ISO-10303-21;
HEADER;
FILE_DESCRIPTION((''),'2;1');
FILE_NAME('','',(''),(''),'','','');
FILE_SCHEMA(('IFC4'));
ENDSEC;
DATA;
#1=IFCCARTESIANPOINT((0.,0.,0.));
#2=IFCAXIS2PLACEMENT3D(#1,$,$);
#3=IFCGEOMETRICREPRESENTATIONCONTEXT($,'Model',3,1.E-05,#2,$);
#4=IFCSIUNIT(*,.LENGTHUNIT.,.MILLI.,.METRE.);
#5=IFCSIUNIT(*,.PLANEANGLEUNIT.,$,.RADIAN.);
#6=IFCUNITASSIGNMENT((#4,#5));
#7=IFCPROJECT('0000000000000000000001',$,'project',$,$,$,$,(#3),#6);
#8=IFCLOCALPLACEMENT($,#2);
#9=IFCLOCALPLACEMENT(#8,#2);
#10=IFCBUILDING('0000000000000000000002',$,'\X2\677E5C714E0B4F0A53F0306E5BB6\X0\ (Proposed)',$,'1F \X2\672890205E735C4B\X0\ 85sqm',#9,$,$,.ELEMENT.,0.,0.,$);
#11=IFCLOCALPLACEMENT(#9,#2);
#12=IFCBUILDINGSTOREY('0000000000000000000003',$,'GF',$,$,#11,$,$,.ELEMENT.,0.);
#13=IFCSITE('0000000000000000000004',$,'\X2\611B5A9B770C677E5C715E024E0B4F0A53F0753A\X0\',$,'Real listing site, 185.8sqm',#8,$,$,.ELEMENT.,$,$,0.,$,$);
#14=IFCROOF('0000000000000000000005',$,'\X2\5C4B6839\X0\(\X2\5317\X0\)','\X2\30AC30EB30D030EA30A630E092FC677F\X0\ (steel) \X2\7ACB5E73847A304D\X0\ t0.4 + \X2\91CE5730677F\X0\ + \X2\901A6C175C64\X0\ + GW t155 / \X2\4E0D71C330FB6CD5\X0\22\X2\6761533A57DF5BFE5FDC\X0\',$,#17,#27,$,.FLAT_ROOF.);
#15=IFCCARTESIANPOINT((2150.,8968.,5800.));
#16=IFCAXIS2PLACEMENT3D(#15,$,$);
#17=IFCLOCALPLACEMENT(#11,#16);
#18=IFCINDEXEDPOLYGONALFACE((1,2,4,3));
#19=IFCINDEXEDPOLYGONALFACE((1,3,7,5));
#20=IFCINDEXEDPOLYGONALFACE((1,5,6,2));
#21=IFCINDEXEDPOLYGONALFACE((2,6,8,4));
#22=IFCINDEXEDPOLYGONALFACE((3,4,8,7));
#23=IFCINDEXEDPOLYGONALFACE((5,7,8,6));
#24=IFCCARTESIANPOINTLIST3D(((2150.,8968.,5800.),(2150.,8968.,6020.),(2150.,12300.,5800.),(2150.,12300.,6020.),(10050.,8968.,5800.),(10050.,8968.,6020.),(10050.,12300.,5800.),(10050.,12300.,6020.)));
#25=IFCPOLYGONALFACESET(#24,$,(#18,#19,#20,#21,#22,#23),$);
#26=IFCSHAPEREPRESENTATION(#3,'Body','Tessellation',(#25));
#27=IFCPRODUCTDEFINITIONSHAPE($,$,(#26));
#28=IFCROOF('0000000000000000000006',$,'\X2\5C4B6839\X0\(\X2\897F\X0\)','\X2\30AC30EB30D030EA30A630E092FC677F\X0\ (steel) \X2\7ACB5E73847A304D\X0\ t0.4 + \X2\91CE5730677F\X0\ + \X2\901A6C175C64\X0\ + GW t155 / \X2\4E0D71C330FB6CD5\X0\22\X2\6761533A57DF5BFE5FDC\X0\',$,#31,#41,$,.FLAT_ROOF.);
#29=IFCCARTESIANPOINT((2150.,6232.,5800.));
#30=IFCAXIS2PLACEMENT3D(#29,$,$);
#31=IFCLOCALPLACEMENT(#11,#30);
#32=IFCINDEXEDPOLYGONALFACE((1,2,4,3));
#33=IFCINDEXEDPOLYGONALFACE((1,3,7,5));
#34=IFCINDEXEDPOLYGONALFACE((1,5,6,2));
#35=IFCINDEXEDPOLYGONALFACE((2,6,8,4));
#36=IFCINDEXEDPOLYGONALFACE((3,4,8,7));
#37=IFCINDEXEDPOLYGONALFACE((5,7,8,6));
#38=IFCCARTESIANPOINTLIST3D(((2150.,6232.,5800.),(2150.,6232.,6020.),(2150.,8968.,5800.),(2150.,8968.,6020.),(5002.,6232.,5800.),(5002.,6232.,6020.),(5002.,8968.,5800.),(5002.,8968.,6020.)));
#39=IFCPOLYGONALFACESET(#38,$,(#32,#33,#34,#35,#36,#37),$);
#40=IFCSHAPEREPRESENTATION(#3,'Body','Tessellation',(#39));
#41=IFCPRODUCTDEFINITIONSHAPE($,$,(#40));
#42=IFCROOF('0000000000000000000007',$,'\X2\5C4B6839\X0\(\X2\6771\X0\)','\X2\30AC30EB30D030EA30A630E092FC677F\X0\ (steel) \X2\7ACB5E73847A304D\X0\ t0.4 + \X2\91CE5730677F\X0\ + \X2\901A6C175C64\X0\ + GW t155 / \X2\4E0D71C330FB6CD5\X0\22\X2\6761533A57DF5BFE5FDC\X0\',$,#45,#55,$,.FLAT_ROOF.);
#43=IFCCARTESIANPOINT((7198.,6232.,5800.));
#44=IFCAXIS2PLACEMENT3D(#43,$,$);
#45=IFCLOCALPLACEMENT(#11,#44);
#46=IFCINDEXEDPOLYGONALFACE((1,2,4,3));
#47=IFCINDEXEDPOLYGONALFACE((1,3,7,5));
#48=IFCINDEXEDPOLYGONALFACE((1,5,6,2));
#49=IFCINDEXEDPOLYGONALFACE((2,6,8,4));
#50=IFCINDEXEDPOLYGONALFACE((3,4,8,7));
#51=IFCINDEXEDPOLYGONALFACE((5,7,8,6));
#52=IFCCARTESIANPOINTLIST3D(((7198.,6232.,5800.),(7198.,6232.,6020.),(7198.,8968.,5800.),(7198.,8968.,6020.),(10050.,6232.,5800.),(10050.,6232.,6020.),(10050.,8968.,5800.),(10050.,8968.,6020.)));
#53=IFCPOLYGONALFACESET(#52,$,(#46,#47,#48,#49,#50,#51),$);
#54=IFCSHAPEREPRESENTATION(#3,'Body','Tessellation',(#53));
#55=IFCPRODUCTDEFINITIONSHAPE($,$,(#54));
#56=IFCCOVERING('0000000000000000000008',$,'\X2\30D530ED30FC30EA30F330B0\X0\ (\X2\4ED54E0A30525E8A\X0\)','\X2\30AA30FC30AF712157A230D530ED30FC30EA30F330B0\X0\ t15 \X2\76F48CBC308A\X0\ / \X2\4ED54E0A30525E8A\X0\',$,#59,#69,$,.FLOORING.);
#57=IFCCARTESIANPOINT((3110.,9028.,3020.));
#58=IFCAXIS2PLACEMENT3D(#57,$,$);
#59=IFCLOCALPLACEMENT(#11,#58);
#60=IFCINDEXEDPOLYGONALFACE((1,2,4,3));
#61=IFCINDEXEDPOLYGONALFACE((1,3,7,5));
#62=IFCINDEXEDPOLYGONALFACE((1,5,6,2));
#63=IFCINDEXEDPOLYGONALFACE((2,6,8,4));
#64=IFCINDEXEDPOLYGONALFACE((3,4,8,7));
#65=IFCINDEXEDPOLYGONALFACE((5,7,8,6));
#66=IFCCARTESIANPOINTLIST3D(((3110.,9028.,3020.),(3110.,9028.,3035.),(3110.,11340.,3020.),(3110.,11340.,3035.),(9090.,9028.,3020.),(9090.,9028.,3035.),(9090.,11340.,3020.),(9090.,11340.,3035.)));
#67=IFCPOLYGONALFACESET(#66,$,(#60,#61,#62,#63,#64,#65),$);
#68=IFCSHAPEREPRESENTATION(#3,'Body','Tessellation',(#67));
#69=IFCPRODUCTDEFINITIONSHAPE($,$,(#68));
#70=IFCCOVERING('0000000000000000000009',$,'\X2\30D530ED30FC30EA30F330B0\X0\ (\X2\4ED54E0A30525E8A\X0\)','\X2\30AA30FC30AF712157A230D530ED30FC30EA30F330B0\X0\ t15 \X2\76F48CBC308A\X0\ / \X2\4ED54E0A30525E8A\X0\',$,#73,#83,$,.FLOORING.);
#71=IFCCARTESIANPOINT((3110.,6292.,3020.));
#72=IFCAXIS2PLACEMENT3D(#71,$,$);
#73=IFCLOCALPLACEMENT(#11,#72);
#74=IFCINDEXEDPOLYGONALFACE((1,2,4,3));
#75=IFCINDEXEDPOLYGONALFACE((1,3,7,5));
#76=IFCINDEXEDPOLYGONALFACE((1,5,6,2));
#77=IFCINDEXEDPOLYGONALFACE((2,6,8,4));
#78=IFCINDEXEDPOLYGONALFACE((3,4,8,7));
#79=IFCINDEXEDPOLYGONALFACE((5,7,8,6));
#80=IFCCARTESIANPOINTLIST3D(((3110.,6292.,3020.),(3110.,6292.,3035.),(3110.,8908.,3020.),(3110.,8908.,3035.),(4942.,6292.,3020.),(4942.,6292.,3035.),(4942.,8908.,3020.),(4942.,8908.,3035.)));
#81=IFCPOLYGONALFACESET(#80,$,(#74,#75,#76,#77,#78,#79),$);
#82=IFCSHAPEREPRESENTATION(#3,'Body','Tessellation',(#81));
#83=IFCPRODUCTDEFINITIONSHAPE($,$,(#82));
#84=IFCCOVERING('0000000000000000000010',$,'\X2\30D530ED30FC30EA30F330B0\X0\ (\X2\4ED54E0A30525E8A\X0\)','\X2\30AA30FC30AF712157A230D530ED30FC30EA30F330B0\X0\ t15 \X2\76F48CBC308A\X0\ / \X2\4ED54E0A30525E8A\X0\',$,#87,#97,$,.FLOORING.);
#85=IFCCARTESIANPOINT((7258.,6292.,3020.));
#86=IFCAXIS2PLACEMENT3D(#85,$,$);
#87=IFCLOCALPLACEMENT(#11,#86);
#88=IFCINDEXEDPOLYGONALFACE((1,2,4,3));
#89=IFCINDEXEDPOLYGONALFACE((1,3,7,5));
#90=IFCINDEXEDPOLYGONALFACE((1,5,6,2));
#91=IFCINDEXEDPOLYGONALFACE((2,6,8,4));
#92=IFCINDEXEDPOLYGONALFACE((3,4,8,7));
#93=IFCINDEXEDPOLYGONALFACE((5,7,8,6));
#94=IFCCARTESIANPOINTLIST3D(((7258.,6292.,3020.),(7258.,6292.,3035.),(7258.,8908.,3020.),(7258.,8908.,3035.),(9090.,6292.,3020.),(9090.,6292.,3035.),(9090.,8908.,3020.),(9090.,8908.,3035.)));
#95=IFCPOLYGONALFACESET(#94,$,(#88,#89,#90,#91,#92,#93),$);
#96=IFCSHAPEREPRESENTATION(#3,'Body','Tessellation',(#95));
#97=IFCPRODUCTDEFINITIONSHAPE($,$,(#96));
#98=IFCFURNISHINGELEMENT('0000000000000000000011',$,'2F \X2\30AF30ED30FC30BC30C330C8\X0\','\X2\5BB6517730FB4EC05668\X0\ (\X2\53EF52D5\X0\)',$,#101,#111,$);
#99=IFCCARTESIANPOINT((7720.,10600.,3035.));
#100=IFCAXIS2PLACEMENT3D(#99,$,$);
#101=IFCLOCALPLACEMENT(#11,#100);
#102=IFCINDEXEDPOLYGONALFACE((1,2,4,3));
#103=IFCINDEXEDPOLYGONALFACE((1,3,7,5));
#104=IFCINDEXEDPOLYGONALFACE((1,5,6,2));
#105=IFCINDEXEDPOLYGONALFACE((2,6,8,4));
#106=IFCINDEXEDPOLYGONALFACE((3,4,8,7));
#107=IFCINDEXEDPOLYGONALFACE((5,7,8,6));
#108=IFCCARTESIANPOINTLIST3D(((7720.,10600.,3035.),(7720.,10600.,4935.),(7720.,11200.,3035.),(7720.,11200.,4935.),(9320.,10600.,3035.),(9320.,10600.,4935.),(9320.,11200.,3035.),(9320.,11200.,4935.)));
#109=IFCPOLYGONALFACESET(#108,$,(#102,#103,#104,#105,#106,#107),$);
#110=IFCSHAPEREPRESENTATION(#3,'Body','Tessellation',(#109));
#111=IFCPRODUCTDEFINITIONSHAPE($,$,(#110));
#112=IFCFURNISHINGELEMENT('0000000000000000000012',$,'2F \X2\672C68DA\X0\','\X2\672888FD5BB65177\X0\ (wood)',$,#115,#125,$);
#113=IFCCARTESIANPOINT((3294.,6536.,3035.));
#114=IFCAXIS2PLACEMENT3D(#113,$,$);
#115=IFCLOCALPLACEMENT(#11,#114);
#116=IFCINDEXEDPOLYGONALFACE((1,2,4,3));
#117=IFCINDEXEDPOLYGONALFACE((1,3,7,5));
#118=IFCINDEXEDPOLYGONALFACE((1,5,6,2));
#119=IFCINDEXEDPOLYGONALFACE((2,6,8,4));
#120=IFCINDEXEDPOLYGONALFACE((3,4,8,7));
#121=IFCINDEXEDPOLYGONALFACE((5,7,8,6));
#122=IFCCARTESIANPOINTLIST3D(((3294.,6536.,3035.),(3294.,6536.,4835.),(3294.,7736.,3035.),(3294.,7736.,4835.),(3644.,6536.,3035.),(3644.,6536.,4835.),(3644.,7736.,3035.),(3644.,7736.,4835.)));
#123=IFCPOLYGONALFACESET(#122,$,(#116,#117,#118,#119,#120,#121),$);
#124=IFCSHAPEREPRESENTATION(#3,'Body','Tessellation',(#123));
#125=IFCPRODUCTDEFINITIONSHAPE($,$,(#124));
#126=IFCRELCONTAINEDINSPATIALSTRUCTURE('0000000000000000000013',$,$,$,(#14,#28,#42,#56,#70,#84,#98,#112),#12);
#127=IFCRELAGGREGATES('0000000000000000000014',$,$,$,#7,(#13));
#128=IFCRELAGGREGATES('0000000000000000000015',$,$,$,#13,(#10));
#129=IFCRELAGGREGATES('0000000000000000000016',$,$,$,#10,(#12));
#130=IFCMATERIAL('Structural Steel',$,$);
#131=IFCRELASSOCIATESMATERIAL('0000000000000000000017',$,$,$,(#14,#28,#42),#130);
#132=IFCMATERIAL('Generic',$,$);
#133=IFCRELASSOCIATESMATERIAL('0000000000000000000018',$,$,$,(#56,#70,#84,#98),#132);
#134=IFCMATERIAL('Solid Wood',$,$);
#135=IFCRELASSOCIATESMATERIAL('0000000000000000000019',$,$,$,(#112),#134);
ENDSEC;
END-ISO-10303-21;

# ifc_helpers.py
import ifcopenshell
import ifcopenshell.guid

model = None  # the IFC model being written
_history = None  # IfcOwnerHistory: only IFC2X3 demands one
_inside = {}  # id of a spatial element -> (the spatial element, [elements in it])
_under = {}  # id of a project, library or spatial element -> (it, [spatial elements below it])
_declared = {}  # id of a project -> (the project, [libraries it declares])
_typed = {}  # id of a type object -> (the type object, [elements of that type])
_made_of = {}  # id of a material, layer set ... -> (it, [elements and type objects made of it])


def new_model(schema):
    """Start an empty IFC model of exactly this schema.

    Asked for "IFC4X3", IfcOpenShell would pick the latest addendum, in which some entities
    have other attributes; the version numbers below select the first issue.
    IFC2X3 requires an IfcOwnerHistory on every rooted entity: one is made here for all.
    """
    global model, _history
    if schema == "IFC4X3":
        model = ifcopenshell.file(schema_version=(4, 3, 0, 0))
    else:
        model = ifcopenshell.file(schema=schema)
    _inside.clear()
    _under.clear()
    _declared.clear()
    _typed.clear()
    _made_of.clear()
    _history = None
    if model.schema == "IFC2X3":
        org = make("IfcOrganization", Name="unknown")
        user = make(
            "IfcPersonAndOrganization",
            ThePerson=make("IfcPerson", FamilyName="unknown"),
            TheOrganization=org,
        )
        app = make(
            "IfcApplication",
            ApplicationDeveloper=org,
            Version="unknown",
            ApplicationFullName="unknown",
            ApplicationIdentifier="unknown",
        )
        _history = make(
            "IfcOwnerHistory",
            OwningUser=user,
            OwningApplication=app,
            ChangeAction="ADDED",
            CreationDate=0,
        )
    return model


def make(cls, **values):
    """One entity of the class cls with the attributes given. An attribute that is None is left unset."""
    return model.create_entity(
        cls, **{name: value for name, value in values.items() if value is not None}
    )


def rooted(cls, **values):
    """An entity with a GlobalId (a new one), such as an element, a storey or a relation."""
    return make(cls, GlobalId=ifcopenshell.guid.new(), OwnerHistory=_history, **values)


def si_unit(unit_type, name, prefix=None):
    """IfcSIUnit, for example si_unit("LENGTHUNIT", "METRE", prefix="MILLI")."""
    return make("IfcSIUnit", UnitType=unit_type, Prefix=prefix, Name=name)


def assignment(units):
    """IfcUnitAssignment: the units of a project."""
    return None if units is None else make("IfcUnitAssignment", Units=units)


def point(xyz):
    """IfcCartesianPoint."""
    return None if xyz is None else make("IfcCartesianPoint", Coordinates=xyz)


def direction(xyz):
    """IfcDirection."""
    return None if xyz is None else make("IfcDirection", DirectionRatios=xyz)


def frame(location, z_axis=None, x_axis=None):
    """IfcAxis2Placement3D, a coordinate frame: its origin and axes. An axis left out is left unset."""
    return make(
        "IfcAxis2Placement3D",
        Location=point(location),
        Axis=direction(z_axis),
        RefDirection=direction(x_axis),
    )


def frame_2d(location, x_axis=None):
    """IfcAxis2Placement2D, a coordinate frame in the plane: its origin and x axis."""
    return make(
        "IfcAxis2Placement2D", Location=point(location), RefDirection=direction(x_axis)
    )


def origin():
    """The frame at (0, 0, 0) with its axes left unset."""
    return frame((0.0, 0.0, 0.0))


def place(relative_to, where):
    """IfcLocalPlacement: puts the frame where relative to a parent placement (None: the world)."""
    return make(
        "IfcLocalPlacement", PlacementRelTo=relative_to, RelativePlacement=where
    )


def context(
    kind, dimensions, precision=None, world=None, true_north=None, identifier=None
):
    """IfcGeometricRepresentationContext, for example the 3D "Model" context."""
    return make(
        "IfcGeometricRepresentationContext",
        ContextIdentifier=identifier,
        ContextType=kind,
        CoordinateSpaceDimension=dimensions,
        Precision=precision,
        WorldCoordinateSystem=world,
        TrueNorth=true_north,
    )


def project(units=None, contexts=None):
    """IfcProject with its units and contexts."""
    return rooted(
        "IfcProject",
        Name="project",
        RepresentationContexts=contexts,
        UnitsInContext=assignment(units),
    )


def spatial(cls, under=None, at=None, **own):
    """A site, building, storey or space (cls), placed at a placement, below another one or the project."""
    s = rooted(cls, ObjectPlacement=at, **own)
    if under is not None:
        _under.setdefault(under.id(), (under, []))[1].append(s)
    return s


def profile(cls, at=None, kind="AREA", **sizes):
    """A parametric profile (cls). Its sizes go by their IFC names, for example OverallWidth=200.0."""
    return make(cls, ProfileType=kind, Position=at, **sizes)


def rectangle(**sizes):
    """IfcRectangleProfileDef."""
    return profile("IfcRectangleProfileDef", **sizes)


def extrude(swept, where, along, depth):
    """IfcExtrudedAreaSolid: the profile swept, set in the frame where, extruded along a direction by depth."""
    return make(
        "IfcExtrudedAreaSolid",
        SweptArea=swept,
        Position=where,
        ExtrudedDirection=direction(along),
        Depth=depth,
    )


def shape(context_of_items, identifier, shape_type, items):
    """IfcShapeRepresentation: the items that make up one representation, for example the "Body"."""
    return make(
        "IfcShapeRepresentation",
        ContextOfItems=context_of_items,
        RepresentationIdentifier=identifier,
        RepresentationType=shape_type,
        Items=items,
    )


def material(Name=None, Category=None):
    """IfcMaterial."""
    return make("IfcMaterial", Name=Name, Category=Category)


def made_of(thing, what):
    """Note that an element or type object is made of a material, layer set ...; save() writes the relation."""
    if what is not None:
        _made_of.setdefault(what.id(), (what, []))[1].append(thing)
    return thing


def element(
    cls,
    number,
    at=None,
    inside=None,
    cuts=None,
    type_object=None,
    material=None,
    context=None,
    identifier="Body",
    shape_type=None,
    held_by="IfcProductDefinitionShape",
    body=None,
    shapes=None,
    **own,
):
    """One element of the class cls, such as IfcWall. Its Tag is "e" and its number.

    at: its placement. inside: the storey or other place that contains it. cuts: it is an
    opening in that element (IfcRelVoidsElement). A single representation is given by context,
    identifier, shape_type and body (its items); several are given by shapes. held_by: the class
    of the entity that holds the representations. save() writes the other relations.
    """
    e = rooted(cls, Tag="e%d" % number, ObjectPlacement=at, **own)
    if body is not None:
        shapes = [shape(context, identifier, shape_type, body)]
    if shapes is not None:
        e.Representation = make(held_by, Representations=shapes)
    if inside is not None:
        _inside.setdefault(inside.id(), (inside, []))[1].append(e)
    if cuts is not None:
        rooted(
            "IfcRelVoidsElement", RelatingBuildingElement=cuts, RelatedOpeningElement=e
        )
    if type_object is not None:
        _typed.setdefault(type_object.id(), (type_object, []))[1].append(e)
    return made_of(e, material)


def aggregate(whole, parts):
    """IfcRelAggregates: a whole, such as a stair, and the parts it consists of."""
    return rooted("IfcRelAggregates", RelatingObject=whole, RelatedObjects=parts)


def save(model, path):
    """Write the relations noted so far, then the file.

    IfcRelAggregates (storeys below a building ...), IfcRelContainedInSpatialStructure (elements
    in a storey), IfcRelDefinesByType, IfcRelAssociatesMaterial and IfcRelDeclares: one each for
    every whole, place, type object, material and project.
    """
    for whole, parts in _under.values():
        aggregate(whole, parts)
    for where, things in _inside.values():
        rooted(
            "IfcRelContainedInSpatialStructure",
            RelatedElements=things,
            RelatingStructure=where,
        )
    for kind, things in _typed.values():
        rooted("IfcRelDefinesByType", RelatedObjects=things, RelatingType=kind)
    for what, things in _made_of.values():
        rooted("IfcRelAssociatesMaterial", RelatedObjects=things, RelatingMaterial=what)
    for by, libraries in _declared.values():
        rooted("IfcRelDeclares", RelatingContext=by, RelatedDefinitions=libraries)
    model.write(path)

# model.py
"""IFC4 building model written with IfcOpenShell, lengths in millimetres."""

from ifc_helpers import new_model, si_unit, frame, frame_2d, origin, place, context, project, spatial, rectangle, extrude, material, element, save


model = new_model("IFC4")

# Units and contexts
model_context = context("Model", 3, precision=1e-05, world=origin())
ifc_project = project(units=[si_unit("LENGTHUNIT", "METRE", prefix="MILLI"), si_unit("PLANEANGLEUNIT", "RADIAN")], contexts=[model_context])

# Site, building, storey
site_placement = place(None, origin())
site = spatial("IfcSite", under=ifc_project, at=site_placement, Name="愛媛県松山市下伊台町", ObjectType="Real listing site, 185.8sqm", CompositionType="ELEMENT", RefElevation=0.0)
building_placement = place(site_placement, origin())
building = spatial("IfcBuilding", under=site, at=building_placement, Name="松山下伊台の家 (Proposed)", ObjectType="1F 木造平屋 85sqm", CompositionType="ELEMENT", ElevationOfRefHeight=0.0, ElevationOfTerrain=0.0)
storey_placement = place(building_placement, origin())
storey = spatial("IfcBuildingStorey", under=building, at=storey_placement, Name="GF", CompositionType="ELEMENT", Elevation=0.0)

# Shared definitions
ifc_material_1 = material(Name="Solid Wood")

# Shared definitions
ifc_material_2 = material(Name="Generic")

# Roofs
ifc_material_3 = material(Name="Structural Steel")
for number, where, name in (
    (1, (2150.0, 8968.0, 5800.0), "屋根(北)"),
):
    element("IfcRoof", number, at=place(storey_placement, frame(where)), inside=storey, material=ifc_material_3, Name=name, Description="ガルバリウム鋼板 (steel) 立平葺き t0.4 + 野地板 + 通気層 + GW t155 / 不燃・法22条区域対応", PredefinedType="FLAT_ROOF", context=model_context, shape_type="SweptSolid", body=[
        extrude(rectangle(XDim=7900.0, YDim=3332.0, at=frame_2d((3950.0, 1666.0))), frame((2150.0, 8968.0, 5800.0)), (0.0, 0.0, 1.0), 220.0),
    ])
roof_1_placement = place(storey_placement, frame((2150.0, 6232.0, 5800.0)))
element("IfcRoof", 2, at=roof_1_placement, inside=storey, material=ifc_material_3, Name="屋根(西)", Description="ガルバリウム鋼板 (steel) 立平葺き t0.4 + 野地板 + 通気層 + GW t155 / 不燃・法22条区域対応", PredefinedType="FLAT_ROOF", context=model_context, shape_type="SweptSolid", body=[
    extrude(rectangle(XDim=2852.0, YDim=2736.0, at=frame_2d((1426.0, 1368.0))), frame((2150.0, 6232.0, 5800.0)), (0.0, 0.0, 1.0), 220.0),
])
roof_2_placement = place(storey_placement, frame((7198.0, 6232.0, 5800.0)))
element("IfcRoof", 3, at=roof_2_placement, inside=storey, material=ifc_material_3, Name="屋根(東)", Description="ガルバリウム鋼板 (steel) 立平葺き t0.4 + 野地板 + 通気層 + GW t155 / 不燃・法22条区域対応", PredefinedType="FLAT_ROOF", context=model_context, shape_type="SweptSolid", body=[
    extrude(rectangle(XDim=2852.0, YDim=2736.0, at=frame_2d((1426.0, 1368.0))), frame((7198.0, 6232.0, 5800.0)), (0.0, 0.0, 1.0), 220.0),
])

# Coverings
covering_1_placement = place(storey_placement, frame((3110.0, 9028.0, 3020.0)))
element("IfcCovering", 4, at=covering_1_placement, inside=storey, material=ifc_material_2, Name="フローリング (仕上げ床)", Description="オーク無垢フローリング t15 直貼り / 仕上げ床", PredefinedType="FLOORING", context=model_context, shape_type="SweptSolid", body=[
    extrude(rectangle(XDim=5980.0, YDim=2312.0, at=frame_2d((2990.0, 1156.0))), frame((3110.0, 9028.0, 3020.0)), (0.0, 0.0, 1.0), 15.0),
])
covering_2_placement = place(storey_placement, frame((3110.0, 6292.0, 3020.0)))
element("IfcCovering", 5, at=covering_2_placement, inside=storey, material=ifc_material_2, Name="フローリング (仕上げ床)", Description="オーク無垢フローリング t15 直貼り / 仕上げ床", PredefinedType="FLOORING", context=model_context, shape_type="SweptSolid", body=[
    extrude(rectangle(XDim=1832.0, YDim=2616.0, at=frame_2d((916.0, 1308.0))), frame((3110.0, 6292.0, 3020.0)), (0.0, 0.0, 1.0), 15.0),
])
covering_3_placement = place(storey_placement, frame((7258.0, 6292.0, 3020.0)))
element("IfcCovering", 6, at=covering_3_placement, inside=storey, material=ifc_material_2, Name="フローリング (仕上げ床)", Description="オーク無垢フローリング t15 直貼り / 仕上げ床", PredefinedType="FLOORING", context=model_context, shape_type="SweptSolid", body=[
    extrude(rectangle(XDim=1832.0, YDim=2616.0, at=frame_2d((916.0, 1308.0))), frame((7258.0, 6292.0, 3020.0)), (0.0, 0.0, 1.0), 15.0),
])

# Furnishing elements
furnishing_1_placement = place(storey_placement, frame((7720.0, 10600.0, 3035.0)))
element("IfcFurnishingElement", 7, at=furnishing_1_placement, inside=storey, material=ifc_material_2, Name="2F クローゼット", Description="家具・什器 (可動)", context=model_context, shape_type="SweptSolid", body=[
    extrude(rectangle(XDim=1600.0, YDim=600.0, at=frame_2d((800.0, 300.0))), frame((7720.0, 10600.0, 3035.0)), (0.0, 0.0, 1.0), 1900.0),
])
furnishing_2_placement = place(storey_placement, frame((3294.0, 6536.0, 3035.0)))
element("IfcFurnishingElement", 8, at=furnishing_2_placement, inside=storey, material=ifc_material_1, Name="2F 本棚", Description="木製家具 (wood)", context=model_context, shape_type="SweptSolid", body=[
    extrude(rectangle(XDim=350.0, YDim=1200.0, at=frame_2d((175.0, 600.0))), frame((3294.0, 6536.0, 3035.0)), (0.0, 0.0, 1.0), 1800.0),
])

save(model, "model.ifc")
